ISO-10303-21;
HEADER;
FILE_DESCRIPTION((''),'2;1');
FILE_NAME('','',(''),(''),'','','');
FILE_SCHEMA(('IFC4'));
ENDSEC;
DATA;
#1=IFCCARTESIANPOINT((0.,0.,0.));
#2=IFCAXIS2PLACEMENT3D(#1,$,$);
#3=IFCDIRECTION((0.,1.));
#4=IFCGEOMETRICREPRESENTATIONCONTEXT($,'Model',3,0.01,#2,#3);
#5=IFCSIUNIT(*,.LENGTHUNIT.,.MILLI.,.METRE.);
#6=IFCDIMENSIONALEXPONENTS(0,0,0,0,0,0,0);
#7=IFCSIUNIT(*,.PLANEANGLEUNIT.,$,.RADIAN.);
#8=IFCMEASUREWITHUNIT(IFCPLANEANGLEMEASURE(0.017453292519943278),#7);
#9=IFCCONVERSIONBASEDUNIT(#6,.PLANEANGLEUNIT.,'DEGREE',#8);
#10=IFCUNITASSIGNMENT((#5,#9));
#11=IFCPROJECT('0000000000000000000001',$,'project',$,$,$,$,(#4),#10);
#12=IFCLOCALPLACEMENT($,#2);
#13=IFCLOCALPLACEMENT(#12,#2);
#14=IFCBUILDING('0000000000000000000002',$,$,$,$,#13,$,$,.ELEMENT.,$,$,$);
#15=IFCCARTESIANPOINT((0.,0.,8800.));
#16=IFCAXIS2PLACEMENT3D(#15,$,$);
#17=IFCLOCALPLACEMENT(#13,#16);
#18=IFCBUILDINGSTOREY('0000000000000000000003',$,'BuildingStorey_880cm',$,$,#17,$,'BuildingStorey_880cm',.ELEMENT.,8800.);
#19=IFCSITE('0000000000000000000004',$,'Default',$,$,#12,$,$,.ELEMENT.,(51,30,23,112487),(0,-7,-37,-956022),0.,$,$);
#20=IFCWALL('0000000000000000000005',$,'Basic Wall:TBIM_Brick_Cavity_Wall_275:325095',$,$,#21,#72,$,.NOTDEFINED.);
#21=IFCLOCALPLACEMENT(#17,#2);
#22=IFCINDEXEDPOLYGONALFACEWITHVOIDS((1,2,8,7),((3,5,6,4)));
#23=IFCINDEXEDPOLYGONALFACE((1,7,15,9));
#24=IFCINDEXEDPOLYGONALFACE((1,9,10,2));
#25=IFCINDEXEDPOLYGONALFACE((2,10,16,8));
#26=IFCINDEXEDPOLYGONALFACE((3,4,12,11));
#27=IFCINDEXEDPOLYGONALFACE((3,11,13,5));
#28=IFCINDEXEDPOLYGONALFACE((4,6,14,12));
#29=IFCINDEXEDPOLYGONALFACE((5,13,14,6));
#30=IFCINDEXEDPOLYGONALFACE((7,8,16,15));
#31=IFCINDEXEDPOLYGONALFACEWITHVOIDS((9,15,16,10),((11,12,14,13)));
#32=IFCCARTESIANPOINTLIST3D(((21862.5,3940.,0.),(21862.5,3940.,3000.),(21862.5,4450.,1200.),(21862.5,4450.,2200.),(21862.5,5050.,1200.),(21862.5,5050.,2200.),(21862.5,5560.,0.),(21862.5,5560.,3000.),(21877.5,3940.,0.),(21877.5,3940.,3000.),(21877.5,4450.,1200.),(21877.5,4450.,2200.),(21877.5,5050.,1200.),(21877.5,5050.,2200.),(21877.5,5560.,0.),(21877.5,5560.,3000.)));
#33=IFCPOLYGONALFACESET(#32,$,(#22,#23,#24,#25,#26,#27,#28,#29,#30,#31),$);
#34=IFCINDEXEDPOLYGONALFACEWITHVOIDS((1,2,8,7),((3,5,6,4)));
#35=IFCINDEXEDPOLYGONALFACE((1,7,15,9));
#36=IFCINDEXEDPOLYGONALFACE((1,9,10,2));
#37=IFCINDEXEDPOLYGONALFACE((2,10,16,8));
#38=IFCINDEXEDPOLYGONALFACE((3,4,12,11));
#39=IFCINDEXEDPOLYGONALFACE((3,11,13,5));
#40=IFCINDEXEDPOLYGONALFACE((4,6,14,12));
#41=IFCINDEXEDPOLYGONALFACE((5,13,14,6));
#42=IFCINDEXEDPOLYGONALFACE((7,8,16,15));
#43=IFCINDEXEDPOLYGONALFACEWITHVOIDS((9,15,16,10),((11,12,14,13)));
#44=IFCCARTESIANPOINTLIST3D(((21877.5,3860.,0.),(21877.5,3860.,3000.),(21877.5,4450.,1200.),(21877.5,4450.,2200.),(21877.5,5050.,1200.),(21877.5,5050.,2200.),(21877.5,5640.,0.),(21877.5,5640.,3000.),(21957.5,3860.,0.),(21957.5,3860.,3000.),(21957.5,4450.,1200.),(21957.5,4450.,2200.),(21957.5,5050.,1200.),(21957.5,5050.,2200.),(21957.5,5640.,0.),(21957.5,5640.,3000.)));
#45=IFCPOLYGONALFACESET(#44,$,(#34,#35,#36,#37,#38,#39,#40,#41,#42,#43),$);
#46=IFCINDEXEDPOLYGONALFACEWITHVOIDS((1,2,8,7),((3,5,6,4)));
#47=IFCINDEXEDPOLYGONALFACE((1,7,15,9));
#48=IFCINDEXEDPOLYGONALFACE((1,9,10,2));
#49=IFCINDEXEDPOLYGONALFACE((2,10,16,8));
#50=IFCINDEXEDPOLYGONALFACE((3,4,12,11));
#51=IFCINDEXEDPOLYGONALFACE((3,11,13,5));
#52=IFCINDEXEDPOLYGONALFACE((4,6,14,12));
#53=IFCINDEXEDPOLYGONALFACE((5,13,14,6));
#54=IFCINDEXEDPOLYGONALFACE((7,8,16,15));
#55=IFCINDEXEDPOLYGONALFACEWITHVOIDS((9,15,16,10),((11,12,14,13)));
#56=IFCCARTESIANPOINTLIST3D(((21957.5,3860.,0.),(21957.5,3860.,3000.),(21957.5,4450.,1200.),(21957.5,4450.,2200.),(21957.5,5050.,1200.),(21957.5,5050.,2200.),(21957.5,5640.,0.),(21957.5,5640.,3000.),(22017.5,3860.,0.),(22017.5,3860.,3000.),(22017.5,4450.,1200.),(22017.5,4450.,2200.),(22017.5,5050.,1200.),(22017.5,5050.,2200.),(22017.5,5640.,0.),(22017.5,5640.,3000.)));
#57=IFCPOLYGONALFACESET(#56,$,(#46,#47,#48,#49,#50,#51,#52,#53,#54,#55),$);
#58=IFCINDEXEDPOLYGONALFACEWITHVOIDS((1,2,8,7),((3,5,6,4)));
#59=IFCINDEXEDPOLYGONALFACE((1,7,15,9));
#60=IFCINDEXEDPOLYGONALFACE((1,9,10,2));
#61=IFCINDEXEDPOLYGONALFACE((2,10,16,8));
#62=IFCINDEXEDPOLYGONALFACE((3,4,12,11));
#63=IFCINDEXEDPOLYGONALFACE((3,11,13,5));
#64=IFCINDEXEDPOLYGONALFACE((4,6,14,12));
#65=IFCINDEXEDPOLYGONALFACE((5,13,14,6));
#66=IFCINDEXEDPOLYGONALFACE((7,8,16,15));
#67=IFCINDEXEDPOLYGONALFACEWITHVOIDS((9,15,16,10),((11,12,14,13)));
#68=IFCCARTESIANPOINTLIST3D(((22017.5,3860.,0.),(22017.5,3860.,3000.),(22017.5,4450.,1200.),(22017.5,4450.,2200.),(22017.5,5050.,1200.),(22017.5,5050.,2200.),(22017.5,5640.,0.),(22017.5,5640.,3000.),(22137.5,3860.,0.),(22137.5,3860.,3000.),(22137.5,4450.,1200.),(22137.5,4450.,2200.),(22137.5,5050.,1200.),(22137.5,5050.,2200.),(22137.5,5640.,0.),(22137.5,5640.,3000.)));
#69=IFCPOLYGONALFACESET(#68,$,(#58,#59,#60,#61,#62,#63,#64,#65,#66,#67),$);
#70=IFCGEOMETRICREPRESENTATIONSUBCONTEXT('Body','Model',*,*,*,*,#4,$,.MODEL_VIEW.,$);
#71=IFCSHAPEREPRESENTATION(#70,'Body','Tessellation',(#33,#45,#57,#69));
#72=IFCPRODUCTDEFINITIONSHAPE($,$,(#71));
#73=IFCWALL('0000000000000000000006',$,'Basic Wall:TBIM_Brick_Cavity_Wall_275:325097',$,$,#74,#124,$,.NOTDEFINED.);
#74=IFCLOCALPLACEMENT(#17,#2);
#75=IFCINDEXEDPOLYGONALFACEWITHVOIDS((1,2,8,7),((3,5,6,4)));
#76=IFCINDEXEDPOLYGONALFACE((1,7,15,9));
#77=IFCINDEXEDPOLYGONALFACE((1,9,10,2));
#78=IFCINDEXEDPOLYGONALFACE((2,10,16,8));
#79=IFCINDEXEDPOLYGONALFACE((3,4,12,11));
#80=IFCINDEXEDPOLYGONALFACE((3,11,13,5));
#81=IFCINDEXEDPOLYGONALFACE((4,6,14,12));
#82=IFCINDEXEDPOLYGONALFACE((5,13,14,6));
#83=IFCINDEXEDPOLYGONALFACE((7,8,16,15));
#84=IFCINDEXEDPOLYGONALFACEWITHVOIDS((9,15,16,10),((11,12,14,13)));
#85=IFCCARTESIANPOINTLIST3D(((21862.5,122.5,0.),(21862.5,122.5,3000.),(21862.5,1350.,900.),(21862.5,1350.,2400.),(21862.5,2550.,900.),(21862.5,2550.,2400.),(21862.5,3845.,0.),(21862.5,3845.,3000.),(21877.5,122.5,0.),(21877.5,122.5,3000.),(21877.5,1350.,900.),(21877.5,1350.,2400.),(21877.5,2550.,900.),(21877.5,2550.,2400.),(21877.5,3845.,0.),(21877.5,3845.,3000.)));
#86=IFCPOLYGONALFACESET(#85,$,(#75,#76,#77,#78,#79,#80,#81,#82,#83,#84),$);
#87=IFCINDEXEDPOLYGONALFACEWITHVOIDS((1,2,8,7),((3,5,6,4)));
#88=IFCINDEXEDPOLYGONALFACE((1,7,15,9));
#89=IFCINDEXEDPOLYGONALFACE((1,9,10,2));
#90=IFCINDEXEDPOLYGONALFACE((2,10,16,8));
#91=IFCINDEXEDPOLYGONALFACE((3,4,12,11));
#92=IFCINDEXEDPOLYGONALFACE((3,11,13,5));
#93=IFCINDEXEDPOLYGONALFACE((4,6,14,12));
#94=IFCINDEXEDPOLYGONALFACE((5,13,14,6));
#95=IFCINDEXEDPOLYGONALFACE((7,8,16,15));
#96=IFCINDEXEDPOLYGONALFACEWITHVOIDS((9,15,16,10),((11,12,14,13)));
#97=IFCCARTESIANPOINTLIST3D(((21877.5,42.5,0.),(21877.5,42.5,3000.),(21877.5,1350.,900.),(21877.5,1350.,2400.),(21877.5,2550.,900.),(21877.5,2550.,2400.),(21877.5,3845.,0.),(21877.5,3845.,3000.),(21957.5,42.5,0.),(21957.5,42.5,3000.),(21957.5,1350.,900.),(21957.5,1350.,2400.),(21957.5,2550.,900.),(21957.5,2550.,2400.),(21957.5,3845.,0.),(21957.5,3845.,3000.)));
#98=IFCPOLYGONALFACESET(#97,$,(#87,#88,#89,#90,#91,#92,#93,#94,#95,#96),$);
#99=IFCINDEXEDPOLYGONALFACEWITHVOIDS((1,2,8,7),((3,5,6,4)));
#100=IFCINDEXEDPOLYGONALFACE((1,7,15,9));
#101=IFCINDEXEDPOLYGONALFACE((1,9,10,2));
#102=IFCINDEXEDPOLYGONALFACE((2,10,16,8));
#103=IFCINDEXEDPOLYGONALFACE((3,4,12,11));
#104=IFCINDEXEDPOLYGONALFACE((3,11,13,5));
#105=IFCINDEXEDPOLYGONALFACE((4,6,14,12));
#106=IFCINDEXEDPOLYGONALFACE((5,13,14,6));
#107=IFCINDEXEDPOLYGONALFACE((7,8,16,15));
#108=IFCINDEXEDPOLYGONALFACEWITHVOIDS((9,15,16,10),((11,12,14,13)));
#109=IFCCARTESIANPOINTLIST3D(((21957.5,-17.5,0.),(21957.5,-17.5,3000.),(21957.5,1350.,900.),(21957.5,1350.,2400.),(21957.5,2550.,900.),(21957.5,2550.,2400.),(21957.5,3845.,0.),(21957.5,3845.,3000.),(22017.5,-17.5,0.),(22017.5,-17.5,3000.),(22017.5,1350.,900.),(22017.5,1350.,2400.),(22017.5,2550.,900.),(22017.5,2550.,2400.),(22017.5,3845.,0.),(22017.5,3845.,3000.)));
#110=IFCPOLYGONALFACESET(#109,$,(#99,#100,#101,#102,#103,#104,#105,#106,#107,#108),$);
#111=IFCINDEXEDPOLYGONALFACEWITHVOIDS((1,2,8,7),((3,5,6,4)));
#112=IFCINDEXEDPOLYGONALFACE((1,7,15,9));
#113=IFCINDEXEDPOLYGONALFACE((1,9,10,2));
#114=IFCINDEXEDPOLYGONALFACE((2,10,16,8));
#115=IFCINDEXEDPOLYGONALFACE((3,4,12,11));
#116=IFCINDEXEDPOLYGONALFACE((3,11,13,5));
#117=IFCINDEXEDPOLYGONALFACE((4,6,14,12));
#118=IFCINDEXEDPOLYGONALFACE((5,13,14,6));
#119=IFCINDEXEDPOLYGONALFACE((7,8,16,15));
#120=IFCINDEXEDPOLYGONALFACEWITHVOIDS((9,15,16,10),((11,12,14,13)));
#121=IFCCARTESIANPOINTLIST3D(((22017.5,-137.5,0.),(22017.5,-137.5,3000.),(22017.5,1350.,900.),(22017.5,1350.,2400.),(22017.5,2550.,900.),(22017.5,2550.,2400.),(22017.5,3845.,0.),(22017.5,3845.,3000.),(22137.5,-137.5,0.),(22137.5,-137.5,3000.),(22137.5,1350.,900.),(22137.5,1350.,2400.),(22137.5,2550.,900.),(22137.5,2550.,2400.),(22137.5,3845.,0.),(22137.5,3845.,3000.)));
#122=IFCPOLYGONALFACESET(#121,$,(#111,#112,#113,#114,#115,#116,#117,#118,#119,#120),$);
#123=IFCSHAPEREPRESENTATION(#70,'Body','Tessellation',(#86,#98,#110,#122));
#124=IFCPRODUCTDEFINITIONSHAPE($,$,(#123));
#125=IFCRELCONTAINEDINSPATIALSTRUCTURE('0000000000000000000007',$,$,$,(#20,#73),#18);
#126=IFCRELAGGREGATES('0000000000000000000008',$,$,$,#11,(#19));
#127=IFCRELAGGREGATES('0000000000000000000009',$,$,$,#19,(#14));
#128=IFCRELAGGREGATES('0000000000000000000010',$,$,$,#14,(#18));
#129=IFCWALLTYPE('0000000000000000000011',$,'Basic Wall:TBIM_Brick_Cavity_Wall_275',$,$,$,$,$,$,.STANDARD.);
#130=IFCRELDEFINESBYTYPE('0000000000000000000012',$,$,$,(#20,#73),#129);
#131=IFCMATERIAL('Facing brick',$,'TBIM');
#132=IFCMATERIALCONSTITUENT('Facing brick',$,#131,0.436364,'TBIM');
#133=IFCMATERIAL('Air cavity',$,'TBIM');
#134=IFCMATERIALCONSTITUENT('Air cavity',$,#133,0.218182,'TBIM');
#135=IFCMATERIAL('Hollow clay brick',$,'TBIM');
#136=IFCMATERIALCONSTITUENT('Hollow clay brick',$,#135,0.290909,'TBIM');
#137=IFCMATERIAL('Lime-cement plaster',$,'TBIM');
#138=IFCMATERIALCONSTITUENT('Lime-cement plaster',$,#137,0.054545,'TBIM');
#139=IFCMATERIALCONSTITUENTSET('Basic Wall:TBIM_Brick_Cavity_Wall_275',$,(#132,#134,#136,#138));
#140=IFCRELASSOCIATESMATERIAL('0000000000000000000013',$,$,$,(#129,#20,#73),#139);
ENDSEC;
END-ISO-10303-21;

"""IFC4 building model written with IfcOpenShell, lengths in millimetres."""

from ifc_helpers import new_model, entity, si_unit, converted_unit, direction, frame, origin, place, context, subcontext, project, spatial, indexed_curve, outline, extrude, material, constituent, constituent_set, type_object, element, save


model = new_model("IFC4")

# Units and contexts
model_context = context("Model", 3, precision=0.01, world=origin(), true_north=direction((0.0, 1.0)))
body_context = subcontext(model_context, "Body", "Model", "MODEL_VIEW")
ifc_project = project(units=[si_unit("LENGTHUNIT", "METRE", prefix="MILLI"), converted_unit("PLANEANGLEUNIT", "DEGREE", entity("IfcPlaneAngleMeasure", 0.017453292519943278), si_unit("PLANEANGLEUNIT", "RADIAN"), dimensions=[0, 0, 0, 0, 0, 0, 0])], contexts=[model_context])

# Site, building, storey
site_placement = place(None, origin())
site = spatial("IfcSite", under=ifc_project, at=site_placement, Name="Default", CompositionType="ELEMENT", RefLatitude=(51, 30, 23, 112487), RefLongitude=(0, -7, -37, -956022), RefElevation=0.0)
building_placement = place(site_placement, origin())
building = spatial("IfcBuilding", under=site, at=building_placement, CompositionType="ELEMENT")
storey_placement = place(building_placement, frame((0.0, 0.0, 8800.0)))
storey = spatial("IfcBuildingStorey", under=building, at=storey_placement, Name="BuildingStorey_880cm", LongName="BuildingStorey_880cm", CompositionType="ELEMENT", Elevation=8800.0)

# Walls, openings
ifc_material_1 = material(Name="Facing brick", Category="TBIM")
ifc_constituent_1 = constituent(ifc_material_1, Name="Facing brick", Category="TBIM", fraction=0.436364)
ifc_material_2 = material(Name="Air cavity", Category="TBIM")
ifc_constituent_2 = constituent(ifc_material_2, Name="Air cavity", Category="TBIM", fraction=0.218182)
ifc_material_3 = material(Name="Hollow clay brick", Category="TBIM")
ifc_constituent_3 = constituent(ifc_material_3, Name="Hollow clay brick", Category="TBIM", fraction=0.290909)
ifc_material_4 = material(Name="Lime-cement plaster", Category="TBIM")
ifc_constituent_4 = constituent(ifc_material_4, Name="Lime-cement plaster", Category="TBIM", fraction=0.054545)
ifc_constituent_set_1 = constituent_set(constituents=[ifc_constituent_1, ifc_constituent_2, ifc_constituent_3, ifc_constituent_4], Name="Basic Wall:TBIM_Brick_Cavity_Wall_275")
wall_type_1 = type_object("IfcWallType", Name="Basic Wall:TBIM_Brick_Cavity_Wall_275", PredefinedType="STANDARD", material=ifc_constituent_set_1)
wall_1_placement = place(storey_placement, frame((22000.0, 5655.0, 0.0), z_axis=(0.0, 0.0, 1.0), x_axis=(0.0, -1.0, 0.0)))
wall_1 = element("IfcWall", 1, at=wall_1_placement, inside=storey, type_object=wall_type_1, material=ifc_constituent_set_1, Name="Basic Wall:TBIM_Brick_Cavity_Wall_275:325095", PredefinedType="NOTDEFINED", context=body_context, shape_type="SweptSolid", body=[
    extrude(outline(indexed_curve([(-1500.0, -810.0), (1500.0, -810.0), (1500.0, -795.0), (1500.0, 795.0), (1500.0, 810.0), (-1500.0, 810.0), (-1500.0, 795.0), (-1500.0, -795.0), (-1500.0, -810.0)], self_intersect=False), holes=[indexed_curve([(700.0, -300.0), (-300.0, -300.0), (-300.0, 300.0), (700.0, 300.0), (700.0, -300.0)], self_intersect=False)]), frame((905.0, -137.5, 1500.0), z_axis=(0.0, 1.0, 0.0), x_axis=(0.0, 0.0, 1.0)), (0.0, 0.0, 1.0), 15.0),
    extrude(outline(indexed_curve([(-1500.0, -890.0), (1500.0, -890.0), (1500.0, 890.0), (-1500.0, 890.0), (-1500.0, -890.0)], self_intersect=False), holes=[indexed_curve([(-300.0, -300.0), (-300.0, 300.0), (700.0, 300.0), (700.0, -300.0), (-300.0, -300.0)], self_intersect=False)]), frame((905.0, -122.5, 1500.0), z_axis=(0.0, 1.0, 0.0), x_axis=(0.0, 0.0, 1.0)), (0.0, 0.0, 1.0), 80.0),
    extrude(outline(indexed_curve([(-1500.0, -890.0), (1500.0, -890.0), (1500.0, 890.0), (-1500.0, 890.0), (-1500.0, -890.0)], self_intersect=False), holes=[indexed_curve([(-300.0, -300.0), (-300.0, 300.0), (700.0, 300.0), (700.0, -300.0), (-300.0, -300.0)], self_intersect=False)]), frame((905.0, -42.5, 1500.0), z_axis=(0.0, 1.0, 0.0), x_axis=(0.0, 0.0, 1.0)), (0.0, 0.0, 1.0), 60.0),
    extrude(outline(indexed_curve([(-1500.0, -890.0), (1500.0, -890.0), (1500.0, 890.0), (-1500.0, 890.0), (-1500.0, -890.0)], self_intersect=False), holes=[indexed_curve([(-300.0, -300.0), (-300.0, 300.0), (700.0, 300.0), (700.0, -300.0), (-300.0, -300.0)], self_intersect=False)]), frame((905.0, 17.5, 1500.0), z_axis=(0.0, 1.0, 0.0), x_axis=(0.0, 0.0, 1.0)), (0.0, 0.0, 1.0), 120.0),
])
opening_1_placement = place(wall_1_placement, frame((605.0, -137.5, 1200.0)))
element("IfcOpeningElement", 2, at=opening_1_placement, cuts=wall_1, PredefinedType="OPENING", context=body_context, shape_type="SweptSolid", body=[
    extrude(outline(indexed_curve([(1000.0, 0.0), (1000.0, 600.0), (0.0, 600.0), (0.0, 0.0), (1000.0, 0.0)], self_intersect=False)), frame((0.0, 0.0, 0.0), z_axis=(0.0, 1.0, 0.0), x_axis=(0.0, 0.0, 1.0)), (0.0, 0.0, 1.0), 275.0),
])
wall_2_placement = place(storey_placement, frame((22000.0, -137.5, 0.0), z_axis=(0.0, 0.0, 1.0), x_axis=(0.0, 1.0, 0.0)))
wall_2 = element("IfcWall", 3, at=wall_2_placement, inside=storey, type_object=wall_type_1, material=ifc_constituent_set_1, Name="Basic Wall:TBIM_Brick_Cavity_Wall_275:325097", PredefinedType="NOTDEFINED", context=body_context, shape_type="SweptSolid", body=[
    extrude(outline(indexed_curve([(-1245.8, -1500.0), (-1230.8, -1500.0), (2476.7, -1500.0), (2476.7, 1500.0), (-1230.8, 1500.0), (-1245.8, 1500.0), (-1245.8, -1500.0)], self_intersect=False), holes=[indexed_curve([(-18.3, 900.0), (1181.7, 900.0), (1181.7, -600.0), (-18.3, -600.0), (-18.3, 900.0)], self_intersect=False)]), frame((1505.8, 137.5, 1500.0), z_axis=(0.0, -1.0, 0.0), x_axis=(1.0, 0.0, 0.0)), (0.0, 0.0, 1.0), 15.0),
    extrude(outline(indexed_curve([(-1500.0, -1901.3), (1500.0, -1901.3), (1500.0, 1901.3), (-1500.0, 1901.3), (-1500.0, -1901.3)], self_intersect=False), holes=[indexed_curve([(900.0, 593.8), (900.0, -606.2), (-600.0, -606.2), (-600.0, 593.8), (900.0, 593.8)], self_intersect=False)]), frame((2081.3, 122.5, 1500.0), z_axis=(0.0, -1.0, 0.0), x_axis=(0.0, 0.0, 1.0)), (0.0, 0.0, 1.0), 80.0),
    extrude(outline(indexed_curve([(-1500.0, -1931.3), (1500.0, -1931.3), (1500.0, 1931.3), (-1500.0, 1931.2), (-1500.0, -1931.3)], self_intersect=False), holes=[indexed_curve([(900.0, 563.8), (900.0, -636.2), (-600.0, -636.2), (-600.0, 563.8), (900.0, 563.8)], self_intersect=False)]), frame((2051.3, 42.5, 1500.0), z_axis=(0.0, -1.0, 0.0), x_axis=(0.0, 0.0, 1.0)), (0.0, 0.0, 1.0), 60.0),
    extrude(outline(indexed_curve([(-1500.0, -1991.3), (1500.0, -1991.3), (1500.0, 1991.3), (-1500.0, 1991.3), (-1500.0, -1991.3)], self_intersect=False), holes=[indexed_curve([(900.0, 503.8), (900.0, -696.2), (-600.0, -696.2), (-600.0, 503.8), (900.0, 503.8)], self_intersect=False)]), frame((1991.3, -17.5, 1500.0), z_axis=(0.0, -1.0, 0.0), x_axis=(0.0, 0.0, 1.0)), (0.0, 0.0, 1.0), 120.0),
])
opening_2_placement = place(wall_2_placement, frame((1487.5, -137.5, 900.0)))
element("IfcOpeningElement", 4, at=opening_2_placement, cuts=wall_2, PredefinedType="OPENING", context=body_context, shape_type="SweptSolid", body=[
    extrude(outline(indexed_curve([(1500.0, 0.0), (1500.0, 1200.0), (0.0, 1200.0), (0.0, 0.0), (1500.0, 0.0)], self_intersect=False)), frame((0.0, 0.0, 0.0), z_axis=(0.0, 1.0, 0.0), x_axis=(0.0, 0.0, 1.0)), (0.0, 0.0, 1.0), 275.0),
])

save(model, "model.ifc")
